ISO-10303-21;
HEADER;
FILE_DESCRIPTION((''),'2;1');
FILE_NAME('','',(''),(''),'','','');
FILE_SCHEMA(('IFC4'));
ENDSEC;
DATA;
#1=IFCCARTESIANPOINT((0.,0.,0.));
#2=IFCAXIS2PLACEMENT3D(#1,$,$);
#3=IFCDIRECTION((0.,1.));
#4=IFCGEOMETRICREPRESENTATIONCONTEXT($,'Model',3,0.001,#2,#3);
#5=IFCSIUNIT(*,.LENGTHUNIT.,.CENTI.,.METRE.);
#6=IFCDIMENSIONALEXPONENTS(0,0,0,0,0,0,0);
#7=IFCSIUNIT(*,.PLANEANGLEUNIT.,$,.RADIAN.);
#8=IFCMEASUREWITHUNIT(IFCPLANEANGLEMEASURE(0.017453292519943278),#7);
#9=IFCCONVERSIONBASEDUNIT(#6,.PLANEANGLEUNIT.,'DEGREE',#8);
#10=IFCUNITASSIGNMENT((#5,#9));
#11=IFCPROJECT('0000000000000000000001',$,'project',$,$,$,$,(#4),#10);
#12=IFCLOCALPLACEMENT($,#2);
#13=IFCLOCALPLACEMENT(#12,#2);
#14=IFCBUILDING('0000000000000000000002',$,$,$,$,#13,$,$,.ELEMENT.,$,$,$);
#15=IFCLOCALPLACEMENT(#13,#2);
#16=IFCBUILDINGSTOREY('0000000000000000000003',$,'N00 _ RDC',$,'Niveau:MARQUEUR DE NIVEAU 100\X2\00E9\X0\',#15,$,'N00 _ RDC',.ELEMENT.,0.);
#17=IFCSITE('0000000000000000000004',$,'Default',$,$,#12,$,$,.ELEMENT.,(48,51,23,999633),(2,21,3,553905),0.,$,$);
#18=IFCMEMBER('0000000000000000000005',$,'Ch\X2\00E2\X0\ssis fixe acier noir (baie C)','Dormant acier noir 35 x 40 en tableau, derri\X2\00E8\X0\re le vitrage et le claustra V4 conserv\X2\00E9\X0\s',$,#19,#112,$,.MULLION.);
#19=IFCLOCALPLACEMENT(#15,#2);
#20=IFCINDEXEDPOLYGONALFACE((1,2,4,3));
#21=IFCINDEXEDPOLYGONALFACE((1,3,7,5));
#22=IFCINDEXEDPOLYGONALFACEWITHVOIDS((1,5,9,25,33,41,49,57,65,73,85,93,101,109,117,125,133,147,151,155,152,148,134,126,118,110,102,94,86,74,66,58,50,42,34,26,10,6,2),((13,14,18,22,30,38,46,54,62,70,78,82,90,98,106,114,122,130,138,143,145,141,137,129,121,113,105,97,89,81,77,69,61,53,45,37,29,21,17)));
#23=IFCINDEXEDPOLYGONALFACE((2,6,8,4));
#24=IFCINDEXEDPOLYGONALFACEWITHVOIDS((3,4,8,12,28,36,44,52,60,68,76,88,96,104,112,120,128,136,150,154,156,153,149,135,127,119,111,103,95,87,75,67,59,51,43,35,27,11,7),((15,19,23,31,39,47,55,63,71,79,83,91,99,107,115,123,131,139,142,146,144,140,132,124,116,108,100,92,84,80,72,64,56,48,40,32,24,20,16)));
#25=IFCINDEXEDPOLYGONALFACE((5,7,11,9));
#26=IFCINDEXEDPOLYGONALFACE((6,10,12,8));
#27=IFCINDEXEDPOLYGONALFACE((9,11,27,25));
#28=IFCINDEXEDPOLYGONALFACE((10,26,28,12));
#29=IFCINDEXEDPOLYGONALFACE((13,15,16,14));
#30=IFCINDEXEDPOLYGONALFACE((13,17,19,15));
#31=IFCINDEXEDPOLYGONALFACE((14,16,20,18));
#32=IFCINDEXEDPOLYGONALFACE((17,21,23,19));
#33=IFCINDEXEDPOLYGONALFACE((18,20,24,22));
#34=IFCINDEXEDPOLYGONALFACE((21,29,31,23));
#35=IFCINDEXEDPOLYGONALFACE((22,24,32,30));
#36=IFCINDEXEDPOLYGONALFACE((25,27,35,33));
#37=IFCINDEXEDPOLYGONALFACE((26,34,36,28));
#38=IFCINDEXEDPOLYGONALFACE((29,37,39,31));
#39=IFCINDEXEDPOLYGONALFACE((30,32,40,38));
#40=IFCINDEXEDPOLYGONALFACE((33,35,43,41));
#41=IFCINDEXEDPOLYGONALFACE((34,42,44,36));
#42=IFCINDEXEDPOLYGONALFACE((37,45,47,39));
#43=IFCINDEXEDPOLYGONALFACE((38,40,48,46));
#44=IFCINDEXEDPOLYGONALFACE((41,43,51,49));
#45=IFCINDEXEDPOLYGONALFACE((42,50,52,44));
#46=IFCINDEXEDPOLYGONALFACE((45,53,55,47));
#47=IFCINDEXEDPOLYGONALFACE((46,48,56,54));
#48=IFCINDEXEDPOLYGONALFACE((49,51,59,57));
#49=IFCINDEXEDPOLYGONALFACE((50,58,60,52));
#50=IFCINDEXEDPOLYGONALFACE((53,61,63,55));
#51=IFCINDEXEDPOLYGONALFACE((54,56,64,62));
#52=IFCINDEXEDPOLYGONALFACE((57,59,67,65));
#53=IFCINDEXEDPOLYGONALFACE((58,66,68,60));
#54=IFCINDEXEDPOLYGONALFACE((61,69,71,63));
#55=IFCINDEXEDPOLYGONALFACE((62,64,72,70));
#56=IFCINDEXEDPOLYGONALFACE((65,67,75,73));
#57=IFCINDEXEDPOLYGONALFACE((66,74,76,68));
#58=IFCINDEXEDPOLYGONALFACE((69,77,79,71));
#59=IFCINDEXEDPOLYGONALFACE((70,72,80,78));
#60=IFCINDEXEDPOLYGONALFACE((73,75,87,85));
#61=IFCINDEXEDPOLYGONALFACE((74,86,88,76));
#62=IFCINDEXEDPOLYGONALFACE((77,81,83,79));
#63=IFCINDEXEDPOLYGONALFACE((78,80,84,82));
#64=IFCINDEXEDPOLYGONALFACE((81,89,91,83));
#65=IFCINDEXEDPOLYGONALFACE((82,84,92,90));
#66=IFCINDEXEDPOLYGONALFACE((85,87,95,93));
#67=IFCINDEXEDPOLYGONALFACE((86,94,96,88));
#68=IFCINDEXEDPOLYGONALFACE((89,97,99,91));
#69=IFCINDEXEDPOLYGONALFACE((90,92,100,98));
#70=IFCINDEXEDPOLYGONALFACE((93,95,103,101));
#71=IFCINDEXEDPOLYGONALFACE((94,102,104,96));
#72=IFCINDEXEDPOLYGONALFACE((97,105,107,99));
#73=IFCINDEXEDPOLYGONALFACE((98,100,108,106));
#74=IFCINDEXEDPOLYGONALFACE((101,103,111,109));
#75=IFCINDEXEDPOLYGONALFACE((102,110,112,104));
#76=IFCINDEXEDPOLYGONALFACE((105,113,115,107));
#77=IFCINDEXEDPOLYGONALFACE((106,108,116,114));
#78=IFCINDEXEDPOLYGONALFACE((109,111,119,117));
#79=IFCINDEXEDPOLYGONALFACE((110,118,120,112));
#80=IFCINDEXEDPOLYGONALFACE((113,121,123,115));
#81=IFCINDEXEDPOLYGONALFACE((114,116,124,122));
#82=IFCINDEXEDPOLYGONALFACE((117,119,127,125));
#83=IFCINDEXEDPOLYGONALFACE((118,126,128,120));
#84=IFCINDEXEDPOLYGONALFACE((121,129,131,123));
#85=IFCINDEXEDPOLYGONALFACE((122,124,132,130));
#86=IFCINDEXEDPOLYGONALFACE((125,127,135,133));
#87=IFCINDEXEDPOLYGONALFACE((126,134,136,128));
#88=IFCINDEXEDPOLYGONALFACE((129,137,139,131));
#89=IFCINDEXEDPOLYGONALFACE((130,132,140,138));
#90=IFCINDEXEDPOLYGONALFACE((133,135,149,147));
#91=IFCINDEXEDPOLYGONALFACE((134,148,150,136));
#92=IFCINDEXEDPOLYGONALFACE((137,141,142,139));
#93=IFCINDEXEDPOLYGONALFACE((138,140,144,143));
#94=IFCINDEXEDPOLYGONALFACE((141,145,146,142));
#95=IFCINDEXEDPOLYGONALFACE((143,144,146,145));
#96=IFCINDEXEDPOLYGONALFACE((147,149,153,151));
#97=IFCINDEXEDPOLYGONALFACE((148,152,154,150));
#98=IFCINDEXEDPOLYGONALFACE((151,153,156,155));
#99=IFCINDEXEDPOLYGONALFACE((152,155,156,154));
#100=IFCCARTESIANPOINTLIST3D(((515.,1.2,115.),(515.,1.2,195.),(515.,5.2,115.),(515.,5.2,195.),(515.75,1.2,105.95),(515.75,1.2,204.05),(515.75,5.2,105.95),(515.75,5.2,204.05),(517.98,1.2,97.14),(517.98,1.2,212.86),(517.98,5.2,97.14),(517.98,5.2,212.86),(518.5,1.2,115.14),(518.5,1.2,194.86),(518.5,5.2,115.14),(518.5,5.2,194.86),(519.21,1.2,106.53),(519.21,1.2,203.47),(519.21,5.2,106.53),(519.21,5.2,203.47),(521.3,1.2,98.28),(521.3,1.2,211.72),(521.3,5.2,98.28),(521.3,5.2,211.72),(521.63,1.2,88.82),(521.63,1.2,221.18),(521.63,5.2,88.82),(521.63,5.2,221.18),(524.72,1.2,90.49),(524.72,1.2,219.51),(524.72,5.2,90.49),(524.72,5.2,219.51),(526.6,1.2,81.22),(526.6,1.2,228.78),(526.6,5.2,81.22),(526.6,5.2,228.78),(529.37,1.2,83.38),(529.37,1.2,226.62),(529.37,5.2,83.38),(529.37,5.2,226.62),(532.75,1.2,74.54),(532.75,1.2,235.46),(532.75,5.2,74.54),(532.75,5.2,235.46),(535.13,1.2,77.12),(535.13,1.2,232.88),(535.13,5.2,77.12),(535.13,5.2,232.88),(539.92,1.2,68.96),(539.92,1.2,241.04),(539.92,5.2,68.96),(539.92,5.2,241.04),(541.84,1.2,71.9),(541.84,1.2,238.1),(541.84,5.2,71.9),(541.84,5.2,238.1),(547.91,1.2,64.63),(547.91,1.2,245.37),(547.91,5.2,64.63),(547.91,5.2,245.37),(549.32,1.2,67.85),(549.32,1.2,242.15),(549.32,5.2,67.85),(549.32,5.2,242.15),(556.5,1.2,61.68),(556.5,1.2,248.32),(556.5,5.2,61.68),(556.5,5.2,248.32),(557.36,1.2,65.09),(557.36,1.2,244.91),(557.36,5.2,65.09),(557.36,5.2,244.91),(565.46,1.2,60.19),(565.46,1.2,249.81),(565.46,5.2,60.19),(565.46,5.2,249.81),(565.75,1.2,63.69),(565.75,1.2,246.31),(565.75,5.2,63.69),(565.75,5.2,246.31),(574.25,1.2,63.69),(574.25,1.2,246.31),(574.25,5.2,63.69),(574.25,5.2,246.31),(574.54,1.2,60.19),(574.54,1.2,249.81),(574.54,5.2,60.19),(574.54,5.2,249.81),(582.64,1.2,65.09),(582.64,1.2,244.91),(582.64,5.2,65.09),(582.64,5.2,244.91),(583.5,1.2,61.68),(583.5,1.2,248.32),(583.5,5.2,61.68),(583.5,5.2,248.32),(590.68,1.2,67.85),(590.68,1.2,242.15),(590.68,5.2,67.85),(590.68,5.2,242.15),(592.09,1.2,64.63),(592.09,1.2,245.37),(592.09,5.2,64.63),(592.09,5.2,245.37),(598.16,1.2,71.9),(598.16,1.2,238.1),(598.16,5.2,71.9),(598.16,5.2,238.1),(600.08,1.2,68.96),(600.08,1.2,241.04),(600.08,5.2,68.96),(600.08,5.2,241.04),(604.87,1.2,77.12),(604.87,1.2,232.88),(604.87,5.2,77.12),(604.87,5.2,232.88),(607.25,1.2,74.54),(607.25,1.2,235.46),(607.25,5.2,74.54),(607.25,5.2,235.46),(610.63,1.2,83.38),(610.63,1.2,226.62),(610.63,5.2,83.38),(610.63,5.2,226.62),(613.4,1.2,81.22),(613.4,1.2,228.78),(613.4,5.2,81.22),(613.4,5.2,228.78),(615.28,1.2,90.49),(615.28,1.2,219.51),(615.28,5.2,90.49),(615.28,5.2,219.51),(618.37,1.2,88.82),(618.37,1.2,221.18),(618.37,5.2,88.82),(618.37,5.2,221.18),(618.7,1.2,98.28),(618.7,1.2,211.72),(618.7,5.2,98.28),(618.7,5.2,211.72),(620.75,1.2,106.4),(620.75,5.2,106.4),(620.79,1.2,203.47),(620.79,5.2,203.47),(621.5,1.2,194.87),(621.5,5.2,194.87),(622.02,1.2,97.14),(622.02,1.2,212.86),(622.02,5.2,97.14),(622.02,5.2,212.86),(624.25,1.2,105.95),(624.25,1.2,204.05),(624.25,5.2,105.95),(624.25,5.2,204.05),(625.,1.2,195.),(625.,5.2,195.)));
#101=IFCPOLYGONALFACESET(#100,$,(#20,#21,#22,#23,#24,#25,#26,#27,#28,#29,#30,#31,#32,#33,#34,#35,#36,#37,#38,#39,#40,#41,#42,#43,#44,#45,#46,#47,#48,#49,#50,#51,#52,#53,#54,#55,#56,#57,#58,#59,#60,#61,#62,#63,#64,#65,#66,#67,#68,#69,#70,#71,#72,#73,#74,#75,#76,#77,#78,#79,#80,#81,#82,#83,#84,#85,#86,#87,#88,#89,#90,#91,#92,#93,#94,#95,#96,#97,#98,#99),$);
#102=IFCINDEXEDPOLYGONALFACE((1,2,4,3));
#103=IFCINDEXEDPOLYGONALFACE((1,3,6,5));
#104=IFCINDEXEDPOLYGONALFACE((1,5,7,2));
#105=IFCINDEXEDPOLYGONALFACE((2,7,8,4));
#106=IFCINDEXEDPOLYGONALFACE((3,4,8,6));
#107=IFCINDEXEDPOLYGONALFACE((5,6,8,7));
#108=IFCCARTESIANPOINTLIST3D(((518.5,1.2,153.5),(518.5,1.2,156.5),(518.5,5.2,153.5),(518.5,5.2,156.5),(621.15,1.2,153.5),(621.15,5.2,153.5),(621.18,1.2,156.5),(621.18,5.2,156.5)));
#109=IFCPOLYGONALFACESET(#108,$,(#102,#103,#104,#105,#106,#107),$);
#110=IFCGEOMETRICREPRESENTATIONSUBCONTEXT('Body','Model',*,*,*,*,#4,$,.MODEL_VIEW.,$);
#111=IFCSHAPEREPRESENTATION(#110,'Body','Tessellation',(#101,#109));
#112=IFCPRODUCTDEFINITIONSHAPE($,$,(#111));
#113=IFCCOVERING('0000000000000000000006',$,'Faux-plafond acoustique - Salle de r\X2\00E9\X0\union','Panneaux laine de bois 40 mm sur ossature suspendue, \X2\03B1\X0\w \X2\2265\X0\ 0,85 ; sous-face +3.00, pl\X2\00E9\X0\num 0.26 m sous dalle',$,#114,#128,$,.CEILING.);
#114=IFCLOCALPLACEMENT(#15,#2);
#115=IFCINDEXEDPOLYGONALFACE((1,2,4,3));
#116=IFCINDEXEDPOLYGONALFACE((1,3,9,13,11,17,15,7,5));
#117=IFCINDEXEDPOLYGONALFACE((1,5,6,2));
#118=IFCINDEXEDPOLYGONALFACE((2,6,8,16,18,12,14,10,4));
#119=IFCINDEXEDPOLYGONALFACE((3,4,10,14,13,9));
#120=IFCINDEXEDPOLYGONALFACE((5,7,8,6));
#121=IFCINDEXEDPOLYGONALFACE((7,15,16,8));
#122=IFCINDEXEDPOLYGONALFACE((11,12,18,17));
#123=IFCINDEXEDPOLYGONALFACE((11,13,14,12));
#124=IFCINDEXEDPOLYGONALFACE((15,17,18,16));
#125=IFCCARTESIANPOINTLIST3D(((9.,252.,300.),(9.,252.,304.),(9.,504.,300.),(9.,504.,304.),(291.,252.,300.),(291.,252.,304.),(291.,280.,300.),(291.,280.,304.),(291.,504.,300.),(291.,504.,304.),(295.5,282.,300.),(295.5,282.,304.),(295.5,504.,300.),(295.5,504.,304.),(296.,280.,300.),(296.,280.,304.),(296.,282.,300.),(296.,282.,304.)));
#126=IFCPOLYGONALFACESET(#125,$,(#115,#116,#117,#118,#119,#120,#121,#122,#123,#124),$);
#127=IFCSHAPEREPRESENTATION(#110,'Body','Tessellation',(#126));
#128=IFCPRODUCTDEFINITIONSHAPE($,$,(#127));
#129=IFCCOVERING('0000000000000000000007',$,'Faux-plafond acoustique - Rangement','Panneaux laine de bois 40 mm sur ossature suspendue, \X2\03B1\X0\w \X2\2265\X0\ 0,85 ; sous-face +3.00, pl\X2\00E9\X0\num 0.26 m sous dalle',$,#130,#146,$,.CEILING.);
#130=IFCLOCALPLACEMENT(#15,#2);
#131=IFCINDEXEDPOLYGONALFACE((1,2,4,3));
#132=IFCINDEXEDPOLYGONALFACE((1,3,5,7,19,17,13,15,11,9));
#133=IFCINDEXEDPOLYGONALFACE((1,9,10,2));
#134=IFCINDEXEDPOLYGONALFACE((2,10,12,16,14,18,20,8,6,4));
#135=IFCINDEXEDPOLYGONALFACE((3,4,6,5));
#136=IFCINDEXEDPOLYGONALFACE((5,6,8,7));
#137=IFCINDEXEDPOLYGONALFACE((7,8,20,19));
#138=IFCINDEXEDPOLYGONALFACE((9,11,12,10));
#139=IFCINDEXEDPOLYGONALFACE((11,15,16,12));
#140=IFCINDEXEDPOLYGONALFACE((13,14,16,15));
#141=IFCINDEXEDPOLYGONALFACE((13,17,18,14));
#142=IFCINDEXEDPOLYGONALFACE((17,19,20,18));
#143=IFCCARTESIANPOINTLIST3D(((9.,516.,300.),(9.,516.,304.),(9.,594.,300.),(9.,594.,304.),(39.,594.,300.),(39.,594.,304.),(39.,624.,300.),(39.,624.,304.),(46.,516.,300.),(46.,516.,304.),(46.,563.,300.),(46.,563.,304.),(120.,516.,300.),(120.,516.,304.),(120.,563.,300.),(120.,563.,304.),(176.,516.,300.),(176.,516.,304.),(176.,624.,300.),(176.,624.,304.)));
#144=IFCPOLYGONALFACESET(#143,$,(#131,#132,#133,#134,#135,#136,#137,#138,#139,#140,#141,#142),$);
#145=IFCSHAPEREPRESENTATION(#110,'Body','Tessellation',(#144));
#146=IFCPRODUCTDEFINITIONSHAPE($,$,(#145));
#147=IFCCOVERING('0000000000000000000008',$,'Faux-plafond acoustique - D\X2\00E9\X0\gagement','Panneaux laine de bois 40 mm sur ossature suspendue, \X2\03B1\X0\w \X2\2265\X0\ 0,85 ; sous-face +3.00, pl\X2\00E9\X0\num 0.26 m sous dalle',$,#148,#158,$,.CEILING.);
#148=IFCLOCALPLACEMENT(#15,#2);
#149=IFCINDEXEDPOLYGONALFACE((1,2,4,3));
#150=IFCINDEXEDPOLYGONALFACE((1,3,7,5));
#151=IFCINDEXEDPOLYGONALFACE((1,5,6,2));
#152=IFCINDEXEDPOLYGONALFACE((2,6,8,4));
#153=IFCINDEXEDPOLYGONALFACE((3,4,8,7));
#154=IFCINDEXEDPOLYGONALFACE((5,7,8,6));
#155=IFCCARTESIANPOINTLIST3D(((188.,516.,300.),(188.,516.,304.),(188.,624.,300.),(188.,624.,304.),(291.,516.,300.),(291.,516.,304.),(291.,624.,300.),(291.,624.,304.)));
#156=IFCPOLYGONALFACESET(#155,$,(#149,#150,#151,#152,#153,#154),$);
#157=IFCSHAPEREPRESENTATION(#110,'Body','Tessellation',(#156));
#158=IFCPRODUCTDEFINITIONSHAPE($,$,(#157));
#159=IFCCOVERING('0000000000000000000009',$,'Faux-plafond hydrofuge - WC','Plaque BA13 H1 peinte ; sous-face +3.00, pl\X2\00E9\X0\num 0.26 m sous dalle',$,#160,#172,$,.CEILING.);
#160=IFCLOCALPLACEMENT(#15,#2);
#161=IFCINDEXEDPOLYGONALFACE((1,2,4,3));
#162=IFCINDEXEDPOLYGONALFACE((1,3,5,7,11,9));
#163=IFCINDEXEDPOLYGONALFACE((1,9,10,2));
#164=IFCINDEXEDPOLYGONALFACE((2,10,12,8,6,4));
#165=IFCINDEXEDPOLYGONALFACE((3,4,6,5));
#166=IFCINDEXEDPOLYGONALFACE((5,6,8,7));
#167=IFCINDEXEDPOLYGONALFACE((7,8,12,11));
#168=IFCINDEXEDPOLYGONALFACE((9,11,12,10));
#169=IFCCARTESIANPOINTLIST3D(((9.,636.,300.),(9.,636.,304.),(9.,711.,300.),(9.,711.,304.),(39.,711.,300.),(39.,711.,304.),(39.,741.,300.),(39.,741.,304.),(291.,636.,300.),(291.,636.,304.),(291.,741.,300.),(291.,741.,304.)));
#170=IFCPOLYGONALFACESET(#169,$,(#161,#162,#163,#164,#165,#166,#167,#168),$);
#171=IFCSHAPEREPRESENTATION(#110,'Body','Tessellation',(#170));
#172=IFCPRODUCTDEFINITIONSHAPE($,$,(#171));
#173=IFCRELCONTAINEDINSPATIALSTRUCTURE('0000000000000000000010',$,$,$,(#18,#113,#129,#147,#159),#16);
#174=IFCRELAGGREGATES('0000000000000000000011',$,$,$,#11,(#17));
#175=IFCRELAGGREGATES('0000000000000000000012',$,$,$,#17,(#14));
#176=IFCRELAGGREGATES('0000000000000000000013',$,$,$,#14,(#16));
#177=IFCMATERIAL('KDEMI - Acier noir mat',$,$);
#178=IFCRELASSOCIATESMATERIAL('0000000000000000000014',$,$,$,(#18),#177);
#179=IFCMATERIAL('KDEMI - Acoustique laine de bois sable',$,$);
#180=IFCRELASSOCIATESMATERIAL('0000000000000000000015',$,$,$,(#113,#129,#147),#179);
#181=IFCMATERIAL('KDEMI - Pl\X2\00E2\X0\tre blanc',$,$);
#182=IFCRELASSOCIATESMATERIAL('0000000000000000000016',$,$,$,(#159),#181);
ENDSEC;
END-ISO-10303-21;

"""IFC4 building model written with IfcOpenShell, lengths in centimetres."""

from ifc_helpers import new_model, entity, si_unit, converted_unit, direction, frame, origin, origin_with_axes, place, context, subcontext, project, spatial, polyline, outline, extrude, material, element, save


model = new_model("IFC4")

# Units and contexts
model_context = context("Model", 3, precision=0.001, world=origin(), true_north=direction((0.0, 1.0)))
body_context = subcontext(model_context, "Body", "Model", "MODEL_VIEW")
ifc_project = project(units=[si_unit("LENGTHUNIT", "METRE", prefix="CENTI"), converted_unit("PLANEANGLEUNIT", "DEGREE", entity("IfcPlaneAngleMeasure", 0.017453292519943278), si_unit("PLANEANGLEUNIT", "RADIAN"), dimensions=[0, 0, 0, 0, 0, 0, 0])], contexts=[model_context])

# Site, building, storey
site_placement = place(None, origin())
site = spatial("IfcSite", under=ifc_project, at=site_placement, Name="Default", CompositionType="ELEMENT", RefLatitude=(48, 51, 23, 999633), RefLongitude=(2, 21, 3, 553905), RefElevation=0.0)
building_placement = place(site_placement, origin())
building = spatial("IfcBuilding", under=site, at=building_placement, CompositionType="ELEMENT")
storey_placement = place(building_placement, origin())
storey = spatial("IfcBuildingStorey", under=building, at=storey_placement, Name="N00 _ RDC", ObjectType="Niveau:MARQUEUR DE NIVEAU 100é", LongName="N00 _ RDC", CompositionType="ELEMENT", Elevation=0.0)

# Member
ifc_material_1 = material(Name="KDEMI - Acier noir mat")
member_1_placement = place(storey_placement, origin_with_axes())
element("IfcMember", 1, at=member_1_placement, inside=storey, material=ifc_material_1, Name="Châssis fixe acier noir (baie C)", Description="Dormant acier noir 35 x 40 en tableau, derrière le vitrage et le claustra V4 conservés", PredefinedType="MULLION", context=body_context, shape_type="SweptSolid", body=[
    extrude(outline(polyline([(624.25, 105.95), (622.02, 97.14), (618.37, 88.82), (613.4, 81.22), (607.25, 74.54), (600.08, 68.96), (592.09, 64.63), (583.5, 61.68), (574.54, 60.19), (565.46, 60.19), (556.5, 61.68), (547.91, 64.63), (539.92, 68.96), (532.75, 74.54), (526.6, 81.22), (521.63, 88.82), (517.98, 97.14), (515.75, 105.95), (515.0, 115.0), (515.0, 195.0), (515.75, 204.05), (517.98, 212.86), (521.63, 221.18), (526.6, 228.78), (532.75, 235.46), (539.92, 241.04), (547.91, 245.37), (556.5, 248.32), (565.46, 249.81), (574.54, 249.81), (583.5, 248.32), (592.09, 245.37), (600.08, 241.04), (607.25, 235.46), (613.4, 228.78), (618.37, 221.18), (622.02, 212.86), (624.25, 204.05), (625.0, 195.0), (624.25, 105.95)]), holes=[polyline([(620.79, 203.47), (618.7, 211.72), (615.28, 219.51), (610.63, 226.62), (604.87, 232.88), (598.16, 238.1), (590.68, 242.15), (582.64, 244.91), (574.25, 246.31), (565.75, 246.31), (557.36, 244.91), (549.32, 242.15), (541.84, 238.1), (535.13, 232.88), (529.37, 226.62), (524.72, 219.51), (521.3, 211.72), (519.21, 203.47), (518.5, 194.86), (518.5, 115.14), (519.21, 106.53), (521.3, 98.28), (524.72, 90.49), (529.37, 83.38), (535.13, 77.12), (541.84, 71.9), (549.32, 67.85), (557.36, 65.09), (565.75, 63.69), (574.25, 63.69), (582.64, 65.09), (590.68, 67.85), (598.16, 71.9), (604.87, 77.12), (610.63, 83.38), (615.28, 90.49), (618.7, 98.28), (620.75, 106.4), (621.5, 194.87), (620.79, 203.47)])]), frame((0.0, 5.2, 0.0), z_axis=(0.0, -1.0, 0.0), x_axis=(1.0, 0.0, 0.0)), (0.0, 0.0, 1.0), 4.0),
    extrude(outline(polyline([(621.18, 156.5), (621.15, 153.5), (518.5, 153.5), (518.5, 156.5), (621.18, 156.5)])), frame((0.0, 5.2, 0.0), z_axis=(0.0, -1.0, 0.0), x_axis=(1.0, 0.0, 0.0)), (0.0, 0.0, 1.0), 4.0),
])

# Coverings
ifc_material_2 = material(Name="KDEMI - Acoustique laine de bois sable")
covering_1_placement = place(storey_placement, origin_with_axes())
element("IfcCovering", 2, at=covering_1_placement, inside=storey, material=ifc_material_2, Name="Faux-plafond acoustique - Salle de réunion", Description="Panneaux laine de bois 40 mm sur ossature suspendue, αw ≥ 0,85 ; sous-face +3.00, plénum 0.26 m sous dalle", PredefinedType="CEILING", context=body_context, shape_type="SweptSolid", body=[
    extrude(outline(polyline([(296.0, 280.0), (291.0, 280.0), (291.0, 252.0), (9.0, 252.0), (9.0, 504.0), (291.0, 504.0), (295.5, 504.0), (295.5, 282.0), (296.0, 282.0), (296.0, 280.0)])), frame((0.0, 0.0, 300.0)), (0.0, 0.0, 1.0), 4.0),
])
covering_2_placement = place(storey_placement, origin_with_axes())
element("IfcCovering", 3, at=covering_2_placement, inside=storey, material=ifc_material_2, Name="Faux-plafond acoustique - Rangement", Description="Panneaux laine de bois 40 mm sur ossature suspendue, αw ≥ 0,85 ; sous-face +3.00, plénum 0.26 m sous dalle", PredefinedType="CEILING", context=body_context, shape_type="SweptSolid", body=[
    extrude(outline(polyline([(120.0, 563.0), (46.0, 563.0), (46.0, 516.0), (9.0, 516.0), (9.0, 594.0), (39.0, 594.0), (39.0, 624.0), (176.0, 624.0), (176.0, 516.0), (120.0, 516.0), (120.0, 563.0)])), frame((0.0, 0.0, 300.0)), (0.0, 0.0, 1.0), 4.0),
])
covering_3_placement = place(storey_placement, origin_with_axes())
element("IfcCovering", 4, at=covering_3_placement, inside=storey, material=ifc_material_2, Name="Faux-plafond acoustique - Dégagement", Description="Panneaux laine de bois 40 mm sur ossature suspendue, αw ≥ 0,85 ; sous-face +3.00, plénum 0.26 m sous dalle", PredefinedType="CEILING", context=body_context, shape_type="SweptSolid", body=[
    extrude(outline(polyline([(291.0, 516.0), (188.0, 516.0), (188.0, 624.0), (291.0, 624.0), (291.0, 516.0)])), frame((0.0, 0.0, 300.0)), (0.0, 0.0, 1.0), 4.0),
])
ifc_material_3 = material(Name="KDEMI - Plâtre blanc")
covering_4_placement = place(storey_placement, origin_with_axes())
element("IfcCovering", 5, at=covering_4_placement, inside=storey, material=ifc_material_3, Name="Faux-plafond hydrofuge - WC", Description="Plaque BA13 H1 peinte ; sous-face +3.00, plénum 0.26 m sous dalle", PredefinedType="CEILING", context=body_context, shape_type="SweptSolid", body=[
    extrude(outline(polyline([(9.0, 636.0), (9.0, 711.0), (39.0, 711.0), (39.0, 741.0), (291.0, 741.0), (291.0, 636.0), (9.0, 636.0)])), frame((0.0, 0.0, 300.0)), (0.0, 0.0, 1.0), 4.0),
])

save(model, "model.ifc")
